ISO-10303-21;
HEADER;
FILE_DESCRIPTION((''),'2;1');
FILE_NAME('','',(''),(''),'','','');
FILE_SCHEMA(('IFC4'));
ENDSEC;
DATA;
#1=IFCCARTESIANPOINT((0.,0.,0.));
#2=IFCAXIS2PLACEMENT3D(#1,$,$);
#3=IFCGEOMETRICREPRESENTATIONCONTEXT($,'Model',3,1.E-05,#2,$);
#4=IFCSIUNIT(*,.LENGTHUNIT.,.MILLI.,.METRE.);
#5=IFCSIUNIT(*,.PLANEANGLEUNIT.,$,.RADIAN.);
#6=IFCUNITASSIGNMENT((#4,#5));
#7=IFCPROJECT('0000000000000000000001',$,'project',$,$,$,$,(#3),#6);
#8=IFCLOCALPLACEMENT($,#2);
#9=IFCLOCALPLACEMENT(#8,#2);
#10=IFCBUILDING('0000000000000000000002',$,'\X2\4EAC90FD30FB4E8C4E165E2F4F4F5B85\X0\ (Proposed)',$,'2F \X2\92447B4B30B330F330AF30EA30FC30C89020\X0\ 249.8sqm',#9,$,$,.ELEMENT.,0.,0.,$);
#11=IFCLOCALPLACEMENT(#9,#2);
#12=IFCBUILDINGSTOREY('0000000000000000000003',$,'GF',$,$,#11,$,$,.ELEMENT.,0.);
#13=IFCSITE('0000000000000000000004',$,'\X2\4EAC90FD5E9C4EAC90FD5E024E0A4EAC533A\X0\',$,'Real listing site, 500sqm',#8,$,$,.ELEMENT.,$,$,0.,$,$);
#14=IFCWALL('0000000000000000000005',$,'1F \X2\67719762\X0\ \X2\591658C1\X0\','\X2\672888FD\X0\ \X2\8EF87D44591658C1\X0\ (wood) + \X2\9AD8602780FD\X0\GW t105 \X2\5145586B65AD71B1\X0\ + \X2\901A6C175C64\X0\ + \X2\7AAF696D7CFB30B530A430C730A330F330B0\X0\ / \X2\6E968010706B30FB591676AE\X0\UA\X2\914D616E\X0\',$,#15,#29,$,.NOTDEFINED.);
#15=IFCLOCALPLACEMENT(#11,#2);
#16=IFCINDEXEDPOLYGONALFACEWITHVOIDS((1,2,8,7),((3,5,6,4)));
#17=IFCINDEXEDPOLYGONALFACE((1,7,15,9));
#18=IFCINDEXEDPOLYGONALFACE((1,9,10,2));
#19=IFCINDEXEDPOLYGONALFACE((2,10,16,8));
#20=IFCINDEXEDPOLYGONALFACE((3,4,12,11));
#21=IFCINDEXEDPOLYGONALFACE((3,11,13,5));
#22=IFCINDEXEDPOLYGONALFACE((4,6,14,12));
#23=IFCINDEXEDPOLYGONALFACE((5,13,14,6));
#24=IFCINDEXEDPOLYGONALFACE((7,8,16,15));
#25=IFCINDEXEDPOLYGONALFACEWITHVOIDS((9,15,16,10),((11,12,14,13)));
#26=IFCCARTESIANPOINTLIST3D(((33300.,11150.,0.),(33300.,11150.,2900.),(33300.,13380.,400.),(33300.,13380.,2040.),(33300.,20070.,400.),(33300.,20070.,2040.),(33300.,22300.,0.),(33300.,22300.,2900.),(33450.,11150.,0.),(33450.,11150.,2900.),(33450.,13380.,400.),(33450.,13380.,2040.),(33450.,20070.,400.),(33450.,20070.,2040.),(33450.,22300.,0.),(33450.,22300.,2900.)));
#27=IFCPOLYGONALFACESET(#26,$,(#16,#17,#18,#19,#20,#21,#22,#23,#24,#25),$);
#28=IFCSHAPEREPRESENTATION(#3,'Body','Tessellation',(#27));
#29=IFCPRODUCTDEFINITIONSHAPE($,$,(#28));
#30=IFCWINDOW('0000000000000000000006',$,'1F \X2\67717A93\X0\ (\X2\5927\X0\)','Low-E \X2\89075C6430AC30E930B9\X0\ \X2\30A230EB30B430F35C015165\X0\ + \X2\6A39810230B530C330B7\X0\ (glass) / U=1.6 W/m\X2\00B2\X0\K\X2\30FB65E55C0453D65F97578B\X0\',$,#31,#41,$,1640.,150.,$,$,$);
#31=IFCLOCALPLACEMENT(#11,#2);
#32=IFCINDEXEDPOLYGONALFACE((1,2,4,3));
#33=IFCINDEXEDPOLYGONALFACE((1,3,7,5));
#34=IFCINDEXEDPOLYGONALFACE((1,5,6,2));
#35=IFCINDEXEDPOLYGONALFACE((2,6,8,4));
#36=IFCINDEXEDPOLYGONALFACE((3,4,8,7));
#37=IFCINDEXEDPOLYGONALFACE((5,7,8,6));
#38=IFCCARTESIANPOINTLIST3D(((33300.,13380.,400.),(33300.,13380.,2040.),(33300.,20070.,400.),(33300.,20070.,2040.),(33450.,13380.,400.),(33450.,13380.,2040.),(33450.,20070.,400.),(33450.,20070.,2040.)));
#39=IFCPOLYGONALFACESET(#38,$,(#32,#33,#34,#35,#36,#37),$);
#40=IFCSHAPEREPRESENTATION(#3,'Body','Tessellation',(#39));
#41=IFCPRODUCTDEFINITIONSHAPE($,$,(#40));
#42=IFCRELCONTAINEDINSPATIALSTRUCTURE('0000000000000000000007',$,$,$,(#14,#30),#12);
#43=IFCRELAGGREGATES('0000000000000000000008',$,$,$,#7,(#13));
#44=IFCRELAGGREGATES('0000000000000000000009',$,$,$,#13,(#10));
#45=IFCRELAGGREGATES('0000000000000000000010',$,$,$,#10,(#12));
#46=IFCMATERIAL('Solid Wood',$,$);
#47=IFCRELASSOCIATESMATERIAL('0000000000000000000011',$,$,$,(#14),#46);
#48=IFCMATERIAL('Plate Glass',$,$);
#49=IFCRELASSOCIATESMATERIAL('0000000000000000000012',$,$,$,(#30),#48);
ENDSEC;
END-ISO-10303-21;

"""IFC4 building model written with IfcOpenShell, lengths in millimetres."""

from ifc_helpers import new_model, si_unit, frame, frame_2d, origin, place, context, project, spatial, rectangle, extrude, material, element, fill, save


model = new_model("IFC4")

# Units and contexts
model_context = context("Model", 3, precision=1e-05, world=origin())
ifc_project = project(units=[si_unit("LENGTHUNIT", "METRE", prefix="MILLI"), si_unit("PLANEANGLEUNIT", "RADIAN")], contexts=[model_context])

# Site, building, storey
site_placement = place(None, origin())
site = spatial("IfcSite", under=ifc_project, at=site_placement, Name="京都府京都市上京区", ObjectType="Real listing site, 500sqm", CompositionType="ELEMENT", RefElevation=0.0)
building_placement = place(site_placement, origin())
building = spatial("IfcBuilding", under=site, at=building_placement, Name="京都・二世帯住宅 (Proposed)", ObjectType="2F 鉄筋コンクリート造 249.8sqm", CompositionType="ELEMENT", ElevationOfRefHeight=0.0, ElevationOfTerrain=0.0)
storey_placement = place(building_placement, origin())
storey = spatial("IfcBuildingStorey", under=building, at=storey_placement, Name="GF", CompositionType="ELEMENT", Elevation=0.0)

# Shared definitions
ifc_material_1 = material(Name="Solid Wood")

# Wall, opening, window
wall_1_placement = place(storey_placement, frame((16650.0, 5575.0, 0.0)))
wall_1 = element("IfcWall", 1, at=wall_1_placement, inside=storey, material=ifc_material_1, Name="1F 東面 外壁", Description="木製 軸組外壁 (wood) + 高性能GW t105 充填断熱 + 通気層 + 窯業系サイディング / 準耐火・外皮UA配慮", PredefinedType="NOTDEFINED", context=model_context, shape_type="SweptSolid", body=[
    extrude(rectangle(XDim=150.0, YDim=11150.0, at=frame_2d((75.0, 5575.0))), frame((16650.0, 5575.0, 0.0)), (0.0, 0.0, 1.0), 2900.0),
])
opening_1_placement = place(storey_placement, frame((16650.0, 6690.0, 200.0)))
opening_1 = element("IfcOpeningElement", 2, at=opening_1_placement, cuts=wall_1, PredefinedType="NOTDEFINED", context=model_context, shape_type="SweptSolid", body=[
    extrude(rectangle(XDim=150.0, YDim=6690.0, at=frame_2d((75.0, 3345.0))), frame((16650.0, 6690.0, 200.0)), (0.0, 0.0, 1.0), 1640.0),
])
ifc_material_2 = material(Name="Plate Glass")
window_1_placement = place(storey_placement, frame((16650.0, 6690.0, 200.0)))
window_1 = element("IfcWindow", 3, at=window_1_placement, inside=storey, material=ifc_material_2, Name="1F 東窓 (大)", Description="Low-E 複層ガラス アルゴン封入 + 樹脂サッシ (glass) / U=1.6 W/m²K・日射取得型", OverallHeight=1640.0, OverallWidth=150.0, context=model_context, shape_type="SweptSolid", body=[
    extrude(rectangle(XDim=150.0, YDim=6690.0, at=frame_2d((75.0, 3345.0))), frame((16650.0, 6690.0, 200.0)), (0.0, 0.0, 1.0), 1640.0),
])
fill(opening_1, window_1)

save(model, "model.ifc")
